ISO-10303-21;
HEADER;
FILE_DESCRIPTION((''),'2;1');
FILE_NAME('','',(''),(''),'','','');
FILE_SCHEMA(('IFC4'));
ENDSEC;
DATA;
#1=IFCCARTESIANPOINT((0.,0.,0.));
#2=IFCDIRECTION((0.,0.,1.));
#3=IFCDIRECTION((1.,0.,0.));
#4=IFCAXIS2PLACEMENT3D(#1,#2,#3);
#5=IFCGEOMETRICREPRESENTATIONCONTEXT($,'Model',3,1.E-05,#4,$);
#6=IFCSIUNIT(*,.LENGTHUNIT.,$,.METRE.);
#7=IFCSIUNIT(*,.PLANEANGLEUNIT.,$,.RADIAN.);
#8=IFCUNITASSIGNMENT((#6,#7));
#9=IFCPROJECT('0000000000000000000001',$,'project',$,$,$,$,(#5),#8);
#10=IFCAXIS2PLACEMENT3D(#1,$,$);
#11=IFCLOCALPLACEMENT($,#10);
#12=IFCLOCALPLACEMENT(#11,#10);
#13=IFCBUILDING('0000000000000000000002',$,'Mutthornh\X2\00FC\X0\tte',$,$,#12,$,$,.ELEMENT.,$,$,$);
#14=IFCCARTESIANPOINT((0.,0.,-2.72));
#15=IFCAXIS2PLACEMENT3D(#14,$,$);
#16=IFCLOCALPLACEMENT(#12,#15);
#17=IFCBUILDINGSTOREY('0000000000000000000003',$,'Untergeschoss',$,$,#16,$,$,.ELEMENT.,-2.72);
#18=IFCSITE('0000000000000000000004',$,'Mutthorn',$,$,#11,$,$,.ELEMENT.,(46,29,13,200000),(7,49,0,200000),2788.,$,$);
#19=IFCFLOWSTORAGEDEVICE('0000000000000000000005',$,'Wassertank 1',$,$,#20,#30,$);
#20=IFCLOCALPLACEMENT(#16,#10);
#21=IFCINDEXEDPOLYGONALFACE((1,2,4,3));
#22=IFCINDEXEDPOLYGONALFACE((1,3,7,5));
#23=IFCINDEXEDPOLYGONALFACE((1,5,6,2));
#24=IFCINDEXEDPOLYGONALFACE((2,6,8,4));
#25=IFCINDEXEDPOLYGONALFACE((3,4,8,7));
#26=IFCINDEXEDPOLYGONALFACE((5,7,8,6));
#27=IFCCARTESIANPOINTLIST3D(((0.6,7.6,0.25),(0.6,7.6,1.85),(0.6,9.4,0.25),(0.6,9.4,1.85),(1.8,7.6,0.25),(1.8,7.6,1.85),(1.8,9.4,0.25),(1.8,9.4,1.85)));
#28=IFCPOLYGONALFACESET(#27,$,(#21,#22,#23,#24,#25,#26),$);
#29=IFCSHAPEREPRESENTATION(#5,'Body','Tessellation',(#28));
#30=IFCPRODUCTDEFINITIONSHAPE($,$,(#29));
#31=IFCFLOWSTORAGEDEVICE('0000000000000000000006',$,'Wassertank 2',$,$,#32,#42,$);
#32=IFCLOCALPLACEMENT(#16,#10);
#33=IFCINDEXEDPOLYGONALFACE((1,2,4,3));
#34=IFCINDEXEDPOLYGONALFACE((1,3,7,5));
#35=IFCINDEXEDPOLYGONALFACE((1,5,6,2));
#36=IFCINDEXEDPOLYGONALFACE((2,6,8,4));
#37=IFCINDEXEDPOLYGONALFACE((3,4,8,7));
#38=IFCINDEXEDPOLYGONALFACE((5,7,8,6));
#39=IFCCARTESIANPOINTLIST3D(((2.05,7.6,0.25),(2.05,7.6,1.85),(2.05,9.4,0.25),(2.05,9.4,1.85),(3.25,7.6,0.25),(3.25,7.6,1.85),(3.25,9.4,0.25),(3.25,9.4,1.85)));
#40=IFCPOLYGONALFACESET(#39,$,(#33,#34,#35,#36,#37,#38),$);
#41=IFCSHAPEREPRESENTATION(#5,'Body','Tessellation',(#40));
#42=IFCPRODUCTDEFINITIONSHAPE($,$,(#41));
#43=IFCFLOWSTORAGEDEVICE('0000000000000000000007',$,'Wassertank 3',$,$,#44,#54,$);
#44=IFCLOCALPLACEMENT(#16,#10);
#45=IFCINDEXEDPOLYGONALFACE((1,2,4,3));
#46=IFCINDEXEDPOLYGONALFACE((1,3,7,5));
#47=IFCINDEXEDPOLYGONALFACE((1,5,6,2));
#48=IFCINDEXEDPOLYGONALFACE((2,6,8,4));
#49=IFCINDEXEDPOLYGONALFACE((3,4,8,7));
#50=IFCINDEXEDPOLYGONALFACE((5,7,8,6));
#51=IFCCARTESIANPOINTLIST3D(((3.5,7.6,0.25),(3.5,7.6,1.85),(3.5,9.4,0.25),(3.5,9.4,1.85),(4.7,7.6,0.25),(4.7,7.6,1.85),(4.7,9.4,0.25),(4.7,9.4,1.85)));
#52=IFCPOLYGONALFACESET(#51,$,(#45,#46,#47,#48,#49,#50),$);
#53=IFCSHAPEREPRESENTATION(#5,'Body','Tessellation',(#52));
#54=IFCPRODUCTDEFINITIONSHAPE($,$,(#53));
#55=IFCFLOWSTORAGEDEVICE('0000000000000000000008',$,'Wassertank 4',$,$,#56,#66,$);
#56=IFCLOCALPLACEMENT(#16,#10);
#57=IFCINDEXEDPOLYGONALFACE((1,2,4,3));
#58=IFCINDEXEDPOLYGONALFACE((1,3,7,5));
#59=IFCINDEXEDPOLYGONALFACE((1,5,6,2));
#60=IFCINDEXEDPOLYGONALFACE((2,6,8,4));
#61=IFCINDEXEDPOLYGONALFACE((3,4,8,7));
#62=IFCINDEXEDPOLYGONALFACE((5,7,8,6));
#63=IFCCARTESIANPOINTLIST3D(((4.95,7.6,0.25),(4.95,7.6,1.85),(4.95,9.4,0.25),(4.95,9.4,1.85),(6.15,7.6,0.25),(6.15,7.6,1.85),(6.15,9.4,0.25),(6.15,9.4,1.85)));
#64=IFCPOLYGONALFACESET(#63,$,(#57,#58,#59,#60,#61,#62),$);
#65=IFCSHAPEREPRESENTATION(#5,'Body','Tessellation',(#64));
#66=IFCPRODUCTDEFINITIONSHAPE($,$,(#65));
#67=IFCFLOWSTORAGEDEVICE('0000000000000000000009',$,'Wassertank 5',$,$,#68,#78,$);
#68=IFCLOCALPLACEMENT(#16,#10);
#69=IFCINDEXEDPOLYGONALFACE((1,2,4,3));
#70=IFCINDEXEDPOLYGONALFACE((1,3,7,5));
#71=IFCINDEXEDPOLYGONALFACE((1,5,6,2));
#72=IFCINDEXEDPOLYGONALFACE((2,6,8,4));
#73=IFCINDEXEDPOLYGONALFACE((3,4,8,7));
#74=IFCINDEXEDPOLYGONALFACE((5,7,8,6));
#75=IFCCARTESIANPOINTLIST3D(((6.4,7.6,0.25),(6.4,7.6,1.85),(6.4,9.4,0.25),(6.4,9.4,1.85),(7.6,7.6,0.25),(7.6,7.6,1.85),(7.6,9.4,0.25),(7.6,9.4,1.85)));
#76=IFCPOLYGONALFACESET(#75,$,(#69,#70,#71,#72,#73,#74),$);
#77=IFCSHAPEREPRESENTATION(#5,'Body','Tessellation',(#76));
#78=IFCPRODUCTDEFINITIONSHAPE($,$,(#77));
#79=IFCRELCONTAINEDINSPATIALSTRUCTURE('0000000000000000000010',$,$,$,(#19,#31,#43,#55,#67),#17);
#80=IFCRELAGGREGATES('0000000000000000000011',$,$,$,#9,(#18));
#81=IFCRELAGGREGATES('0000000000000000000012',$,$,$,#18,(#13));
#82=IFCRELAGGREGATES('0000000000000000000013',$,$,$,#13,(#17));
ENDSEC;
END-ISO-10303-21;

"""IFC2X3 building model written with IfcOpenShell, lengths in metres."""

from ifc_helpers import new_model, si_unit, frame, frame_2d, origin, origin_with_axes, place, context, project, spatial, rectangle, extrude, element, save


model = new_model("IFC2X3")

# Units and contexts
model_context = context("Model", 3, precision=1e-05, world=origin_with_axes())
ifc_project = project(units=[si_unit("LENGTHUNIT", "METRE"), si_unit("PLANEANGLEUNIT", "RADIAN")], contexts=[model_context])

# Site, building, storey
site_placement = place(None, origin())
site = spatial("IfcSite", under=ifc_project, at=site_placement, Name="Mutthorn", CompositionType="ELEMENT", RefLatitude=(46, 29, 13, 200000), RefLongitude=(7, 49, 0, 200000), RefElevation=2788.0)
building_placement = place(site_placement, origin())
building = spatial("IfcBuilding", under=site, at=building_placement, Name="Mutthornhütte", CompositionType="ELEMENT")
storey_placement = place(building_placement, frame((0.0, 0.0, -2.72)))
storey = spatial("IfcBuildingStorey", under=building, at=storey_placement, Name="Untergeschoss", CompositionType="ELEMENT", Elevation=-2.72)

# Flow storage devices
flow_storage_device_1_placement = place(storey_placement, origin())
element("IfcFlowStorageDevice", 1, at=flow_storage_device_1_placement, inside=storey, Name="Wassertank 1", context=model_context, shape_type="SweptSolid", body=[
    extrude(rectangle(XDim=1.2, YDim=1.8, at=frame_2d((0.6, 0.9))), frame((0.6, 7.6, 0.25)), (0.0, 0.0, 1.0), 1.6),
])
flow_storage_device_2_placement = place(storey_placement, origin())
element("IfcFlowStorageDevice", 2, at=flow_storage_device_2_placement, inside=storey, Name="Wassertank 2", context=model_context, shape_type="SweptSolid", body=[
    extrude(rectangle(XDim=1.2, YDim=1.8, at=frame_2d((0.6, 0.9))), frame((2.05, 7.6, 0.25)), (0.0, 0.0, 1.0), 1.6),
])
flow_storage_device_3_placement = place(storey_placement, origin())
element("IfcFlowStorageDevice", 3, at=flow_storage_device_3_placement, inside=storey, Name="Wassertank 3", context=model_context, shape_type="SweptSolid", body=[
    extrude(rectangle(XDim=1.2, YDim=1.8, at=frame_2d((0.6, 0.9))), frame((3.5, 7.6, 0.25)), (0.0, 0.0, 1.0), 1.6),
])
flow_storage_device_4_placement = place(storey_placement, origin())
element("IfcFlowStorageDevice", 4, at=flow_storage_device_4_placement, inside=storey, Name="Wassertank 4", context=model_context, shape_type="SweptSolid", body=[
    extrude(rectangle(XDim=1.2, YDim=1.8, at=frame_2d((0.6, 0.9))), frame((4.95, 7.6, 0.25)), (0.0, 0.0, 1.0), 1.6),
])
flow_storage_device_5_placement = place(storey_placement, origin())
element("IfcFlowStorageDevice", 5, at=flow_storage_device_5_placement, inside=storey, Name="Wassertank 5", context=model_context, shape_type="SweptSolid", body=[
    extrude(rectangle(XDim=1.2, YDim=1.8, at=frame_2d((0.6, 0.9))), frame((6.4, 7.6, 0.25)), (0.0, 0.0, 1.0), 1.6),
])

save(model, "model.ifc")
